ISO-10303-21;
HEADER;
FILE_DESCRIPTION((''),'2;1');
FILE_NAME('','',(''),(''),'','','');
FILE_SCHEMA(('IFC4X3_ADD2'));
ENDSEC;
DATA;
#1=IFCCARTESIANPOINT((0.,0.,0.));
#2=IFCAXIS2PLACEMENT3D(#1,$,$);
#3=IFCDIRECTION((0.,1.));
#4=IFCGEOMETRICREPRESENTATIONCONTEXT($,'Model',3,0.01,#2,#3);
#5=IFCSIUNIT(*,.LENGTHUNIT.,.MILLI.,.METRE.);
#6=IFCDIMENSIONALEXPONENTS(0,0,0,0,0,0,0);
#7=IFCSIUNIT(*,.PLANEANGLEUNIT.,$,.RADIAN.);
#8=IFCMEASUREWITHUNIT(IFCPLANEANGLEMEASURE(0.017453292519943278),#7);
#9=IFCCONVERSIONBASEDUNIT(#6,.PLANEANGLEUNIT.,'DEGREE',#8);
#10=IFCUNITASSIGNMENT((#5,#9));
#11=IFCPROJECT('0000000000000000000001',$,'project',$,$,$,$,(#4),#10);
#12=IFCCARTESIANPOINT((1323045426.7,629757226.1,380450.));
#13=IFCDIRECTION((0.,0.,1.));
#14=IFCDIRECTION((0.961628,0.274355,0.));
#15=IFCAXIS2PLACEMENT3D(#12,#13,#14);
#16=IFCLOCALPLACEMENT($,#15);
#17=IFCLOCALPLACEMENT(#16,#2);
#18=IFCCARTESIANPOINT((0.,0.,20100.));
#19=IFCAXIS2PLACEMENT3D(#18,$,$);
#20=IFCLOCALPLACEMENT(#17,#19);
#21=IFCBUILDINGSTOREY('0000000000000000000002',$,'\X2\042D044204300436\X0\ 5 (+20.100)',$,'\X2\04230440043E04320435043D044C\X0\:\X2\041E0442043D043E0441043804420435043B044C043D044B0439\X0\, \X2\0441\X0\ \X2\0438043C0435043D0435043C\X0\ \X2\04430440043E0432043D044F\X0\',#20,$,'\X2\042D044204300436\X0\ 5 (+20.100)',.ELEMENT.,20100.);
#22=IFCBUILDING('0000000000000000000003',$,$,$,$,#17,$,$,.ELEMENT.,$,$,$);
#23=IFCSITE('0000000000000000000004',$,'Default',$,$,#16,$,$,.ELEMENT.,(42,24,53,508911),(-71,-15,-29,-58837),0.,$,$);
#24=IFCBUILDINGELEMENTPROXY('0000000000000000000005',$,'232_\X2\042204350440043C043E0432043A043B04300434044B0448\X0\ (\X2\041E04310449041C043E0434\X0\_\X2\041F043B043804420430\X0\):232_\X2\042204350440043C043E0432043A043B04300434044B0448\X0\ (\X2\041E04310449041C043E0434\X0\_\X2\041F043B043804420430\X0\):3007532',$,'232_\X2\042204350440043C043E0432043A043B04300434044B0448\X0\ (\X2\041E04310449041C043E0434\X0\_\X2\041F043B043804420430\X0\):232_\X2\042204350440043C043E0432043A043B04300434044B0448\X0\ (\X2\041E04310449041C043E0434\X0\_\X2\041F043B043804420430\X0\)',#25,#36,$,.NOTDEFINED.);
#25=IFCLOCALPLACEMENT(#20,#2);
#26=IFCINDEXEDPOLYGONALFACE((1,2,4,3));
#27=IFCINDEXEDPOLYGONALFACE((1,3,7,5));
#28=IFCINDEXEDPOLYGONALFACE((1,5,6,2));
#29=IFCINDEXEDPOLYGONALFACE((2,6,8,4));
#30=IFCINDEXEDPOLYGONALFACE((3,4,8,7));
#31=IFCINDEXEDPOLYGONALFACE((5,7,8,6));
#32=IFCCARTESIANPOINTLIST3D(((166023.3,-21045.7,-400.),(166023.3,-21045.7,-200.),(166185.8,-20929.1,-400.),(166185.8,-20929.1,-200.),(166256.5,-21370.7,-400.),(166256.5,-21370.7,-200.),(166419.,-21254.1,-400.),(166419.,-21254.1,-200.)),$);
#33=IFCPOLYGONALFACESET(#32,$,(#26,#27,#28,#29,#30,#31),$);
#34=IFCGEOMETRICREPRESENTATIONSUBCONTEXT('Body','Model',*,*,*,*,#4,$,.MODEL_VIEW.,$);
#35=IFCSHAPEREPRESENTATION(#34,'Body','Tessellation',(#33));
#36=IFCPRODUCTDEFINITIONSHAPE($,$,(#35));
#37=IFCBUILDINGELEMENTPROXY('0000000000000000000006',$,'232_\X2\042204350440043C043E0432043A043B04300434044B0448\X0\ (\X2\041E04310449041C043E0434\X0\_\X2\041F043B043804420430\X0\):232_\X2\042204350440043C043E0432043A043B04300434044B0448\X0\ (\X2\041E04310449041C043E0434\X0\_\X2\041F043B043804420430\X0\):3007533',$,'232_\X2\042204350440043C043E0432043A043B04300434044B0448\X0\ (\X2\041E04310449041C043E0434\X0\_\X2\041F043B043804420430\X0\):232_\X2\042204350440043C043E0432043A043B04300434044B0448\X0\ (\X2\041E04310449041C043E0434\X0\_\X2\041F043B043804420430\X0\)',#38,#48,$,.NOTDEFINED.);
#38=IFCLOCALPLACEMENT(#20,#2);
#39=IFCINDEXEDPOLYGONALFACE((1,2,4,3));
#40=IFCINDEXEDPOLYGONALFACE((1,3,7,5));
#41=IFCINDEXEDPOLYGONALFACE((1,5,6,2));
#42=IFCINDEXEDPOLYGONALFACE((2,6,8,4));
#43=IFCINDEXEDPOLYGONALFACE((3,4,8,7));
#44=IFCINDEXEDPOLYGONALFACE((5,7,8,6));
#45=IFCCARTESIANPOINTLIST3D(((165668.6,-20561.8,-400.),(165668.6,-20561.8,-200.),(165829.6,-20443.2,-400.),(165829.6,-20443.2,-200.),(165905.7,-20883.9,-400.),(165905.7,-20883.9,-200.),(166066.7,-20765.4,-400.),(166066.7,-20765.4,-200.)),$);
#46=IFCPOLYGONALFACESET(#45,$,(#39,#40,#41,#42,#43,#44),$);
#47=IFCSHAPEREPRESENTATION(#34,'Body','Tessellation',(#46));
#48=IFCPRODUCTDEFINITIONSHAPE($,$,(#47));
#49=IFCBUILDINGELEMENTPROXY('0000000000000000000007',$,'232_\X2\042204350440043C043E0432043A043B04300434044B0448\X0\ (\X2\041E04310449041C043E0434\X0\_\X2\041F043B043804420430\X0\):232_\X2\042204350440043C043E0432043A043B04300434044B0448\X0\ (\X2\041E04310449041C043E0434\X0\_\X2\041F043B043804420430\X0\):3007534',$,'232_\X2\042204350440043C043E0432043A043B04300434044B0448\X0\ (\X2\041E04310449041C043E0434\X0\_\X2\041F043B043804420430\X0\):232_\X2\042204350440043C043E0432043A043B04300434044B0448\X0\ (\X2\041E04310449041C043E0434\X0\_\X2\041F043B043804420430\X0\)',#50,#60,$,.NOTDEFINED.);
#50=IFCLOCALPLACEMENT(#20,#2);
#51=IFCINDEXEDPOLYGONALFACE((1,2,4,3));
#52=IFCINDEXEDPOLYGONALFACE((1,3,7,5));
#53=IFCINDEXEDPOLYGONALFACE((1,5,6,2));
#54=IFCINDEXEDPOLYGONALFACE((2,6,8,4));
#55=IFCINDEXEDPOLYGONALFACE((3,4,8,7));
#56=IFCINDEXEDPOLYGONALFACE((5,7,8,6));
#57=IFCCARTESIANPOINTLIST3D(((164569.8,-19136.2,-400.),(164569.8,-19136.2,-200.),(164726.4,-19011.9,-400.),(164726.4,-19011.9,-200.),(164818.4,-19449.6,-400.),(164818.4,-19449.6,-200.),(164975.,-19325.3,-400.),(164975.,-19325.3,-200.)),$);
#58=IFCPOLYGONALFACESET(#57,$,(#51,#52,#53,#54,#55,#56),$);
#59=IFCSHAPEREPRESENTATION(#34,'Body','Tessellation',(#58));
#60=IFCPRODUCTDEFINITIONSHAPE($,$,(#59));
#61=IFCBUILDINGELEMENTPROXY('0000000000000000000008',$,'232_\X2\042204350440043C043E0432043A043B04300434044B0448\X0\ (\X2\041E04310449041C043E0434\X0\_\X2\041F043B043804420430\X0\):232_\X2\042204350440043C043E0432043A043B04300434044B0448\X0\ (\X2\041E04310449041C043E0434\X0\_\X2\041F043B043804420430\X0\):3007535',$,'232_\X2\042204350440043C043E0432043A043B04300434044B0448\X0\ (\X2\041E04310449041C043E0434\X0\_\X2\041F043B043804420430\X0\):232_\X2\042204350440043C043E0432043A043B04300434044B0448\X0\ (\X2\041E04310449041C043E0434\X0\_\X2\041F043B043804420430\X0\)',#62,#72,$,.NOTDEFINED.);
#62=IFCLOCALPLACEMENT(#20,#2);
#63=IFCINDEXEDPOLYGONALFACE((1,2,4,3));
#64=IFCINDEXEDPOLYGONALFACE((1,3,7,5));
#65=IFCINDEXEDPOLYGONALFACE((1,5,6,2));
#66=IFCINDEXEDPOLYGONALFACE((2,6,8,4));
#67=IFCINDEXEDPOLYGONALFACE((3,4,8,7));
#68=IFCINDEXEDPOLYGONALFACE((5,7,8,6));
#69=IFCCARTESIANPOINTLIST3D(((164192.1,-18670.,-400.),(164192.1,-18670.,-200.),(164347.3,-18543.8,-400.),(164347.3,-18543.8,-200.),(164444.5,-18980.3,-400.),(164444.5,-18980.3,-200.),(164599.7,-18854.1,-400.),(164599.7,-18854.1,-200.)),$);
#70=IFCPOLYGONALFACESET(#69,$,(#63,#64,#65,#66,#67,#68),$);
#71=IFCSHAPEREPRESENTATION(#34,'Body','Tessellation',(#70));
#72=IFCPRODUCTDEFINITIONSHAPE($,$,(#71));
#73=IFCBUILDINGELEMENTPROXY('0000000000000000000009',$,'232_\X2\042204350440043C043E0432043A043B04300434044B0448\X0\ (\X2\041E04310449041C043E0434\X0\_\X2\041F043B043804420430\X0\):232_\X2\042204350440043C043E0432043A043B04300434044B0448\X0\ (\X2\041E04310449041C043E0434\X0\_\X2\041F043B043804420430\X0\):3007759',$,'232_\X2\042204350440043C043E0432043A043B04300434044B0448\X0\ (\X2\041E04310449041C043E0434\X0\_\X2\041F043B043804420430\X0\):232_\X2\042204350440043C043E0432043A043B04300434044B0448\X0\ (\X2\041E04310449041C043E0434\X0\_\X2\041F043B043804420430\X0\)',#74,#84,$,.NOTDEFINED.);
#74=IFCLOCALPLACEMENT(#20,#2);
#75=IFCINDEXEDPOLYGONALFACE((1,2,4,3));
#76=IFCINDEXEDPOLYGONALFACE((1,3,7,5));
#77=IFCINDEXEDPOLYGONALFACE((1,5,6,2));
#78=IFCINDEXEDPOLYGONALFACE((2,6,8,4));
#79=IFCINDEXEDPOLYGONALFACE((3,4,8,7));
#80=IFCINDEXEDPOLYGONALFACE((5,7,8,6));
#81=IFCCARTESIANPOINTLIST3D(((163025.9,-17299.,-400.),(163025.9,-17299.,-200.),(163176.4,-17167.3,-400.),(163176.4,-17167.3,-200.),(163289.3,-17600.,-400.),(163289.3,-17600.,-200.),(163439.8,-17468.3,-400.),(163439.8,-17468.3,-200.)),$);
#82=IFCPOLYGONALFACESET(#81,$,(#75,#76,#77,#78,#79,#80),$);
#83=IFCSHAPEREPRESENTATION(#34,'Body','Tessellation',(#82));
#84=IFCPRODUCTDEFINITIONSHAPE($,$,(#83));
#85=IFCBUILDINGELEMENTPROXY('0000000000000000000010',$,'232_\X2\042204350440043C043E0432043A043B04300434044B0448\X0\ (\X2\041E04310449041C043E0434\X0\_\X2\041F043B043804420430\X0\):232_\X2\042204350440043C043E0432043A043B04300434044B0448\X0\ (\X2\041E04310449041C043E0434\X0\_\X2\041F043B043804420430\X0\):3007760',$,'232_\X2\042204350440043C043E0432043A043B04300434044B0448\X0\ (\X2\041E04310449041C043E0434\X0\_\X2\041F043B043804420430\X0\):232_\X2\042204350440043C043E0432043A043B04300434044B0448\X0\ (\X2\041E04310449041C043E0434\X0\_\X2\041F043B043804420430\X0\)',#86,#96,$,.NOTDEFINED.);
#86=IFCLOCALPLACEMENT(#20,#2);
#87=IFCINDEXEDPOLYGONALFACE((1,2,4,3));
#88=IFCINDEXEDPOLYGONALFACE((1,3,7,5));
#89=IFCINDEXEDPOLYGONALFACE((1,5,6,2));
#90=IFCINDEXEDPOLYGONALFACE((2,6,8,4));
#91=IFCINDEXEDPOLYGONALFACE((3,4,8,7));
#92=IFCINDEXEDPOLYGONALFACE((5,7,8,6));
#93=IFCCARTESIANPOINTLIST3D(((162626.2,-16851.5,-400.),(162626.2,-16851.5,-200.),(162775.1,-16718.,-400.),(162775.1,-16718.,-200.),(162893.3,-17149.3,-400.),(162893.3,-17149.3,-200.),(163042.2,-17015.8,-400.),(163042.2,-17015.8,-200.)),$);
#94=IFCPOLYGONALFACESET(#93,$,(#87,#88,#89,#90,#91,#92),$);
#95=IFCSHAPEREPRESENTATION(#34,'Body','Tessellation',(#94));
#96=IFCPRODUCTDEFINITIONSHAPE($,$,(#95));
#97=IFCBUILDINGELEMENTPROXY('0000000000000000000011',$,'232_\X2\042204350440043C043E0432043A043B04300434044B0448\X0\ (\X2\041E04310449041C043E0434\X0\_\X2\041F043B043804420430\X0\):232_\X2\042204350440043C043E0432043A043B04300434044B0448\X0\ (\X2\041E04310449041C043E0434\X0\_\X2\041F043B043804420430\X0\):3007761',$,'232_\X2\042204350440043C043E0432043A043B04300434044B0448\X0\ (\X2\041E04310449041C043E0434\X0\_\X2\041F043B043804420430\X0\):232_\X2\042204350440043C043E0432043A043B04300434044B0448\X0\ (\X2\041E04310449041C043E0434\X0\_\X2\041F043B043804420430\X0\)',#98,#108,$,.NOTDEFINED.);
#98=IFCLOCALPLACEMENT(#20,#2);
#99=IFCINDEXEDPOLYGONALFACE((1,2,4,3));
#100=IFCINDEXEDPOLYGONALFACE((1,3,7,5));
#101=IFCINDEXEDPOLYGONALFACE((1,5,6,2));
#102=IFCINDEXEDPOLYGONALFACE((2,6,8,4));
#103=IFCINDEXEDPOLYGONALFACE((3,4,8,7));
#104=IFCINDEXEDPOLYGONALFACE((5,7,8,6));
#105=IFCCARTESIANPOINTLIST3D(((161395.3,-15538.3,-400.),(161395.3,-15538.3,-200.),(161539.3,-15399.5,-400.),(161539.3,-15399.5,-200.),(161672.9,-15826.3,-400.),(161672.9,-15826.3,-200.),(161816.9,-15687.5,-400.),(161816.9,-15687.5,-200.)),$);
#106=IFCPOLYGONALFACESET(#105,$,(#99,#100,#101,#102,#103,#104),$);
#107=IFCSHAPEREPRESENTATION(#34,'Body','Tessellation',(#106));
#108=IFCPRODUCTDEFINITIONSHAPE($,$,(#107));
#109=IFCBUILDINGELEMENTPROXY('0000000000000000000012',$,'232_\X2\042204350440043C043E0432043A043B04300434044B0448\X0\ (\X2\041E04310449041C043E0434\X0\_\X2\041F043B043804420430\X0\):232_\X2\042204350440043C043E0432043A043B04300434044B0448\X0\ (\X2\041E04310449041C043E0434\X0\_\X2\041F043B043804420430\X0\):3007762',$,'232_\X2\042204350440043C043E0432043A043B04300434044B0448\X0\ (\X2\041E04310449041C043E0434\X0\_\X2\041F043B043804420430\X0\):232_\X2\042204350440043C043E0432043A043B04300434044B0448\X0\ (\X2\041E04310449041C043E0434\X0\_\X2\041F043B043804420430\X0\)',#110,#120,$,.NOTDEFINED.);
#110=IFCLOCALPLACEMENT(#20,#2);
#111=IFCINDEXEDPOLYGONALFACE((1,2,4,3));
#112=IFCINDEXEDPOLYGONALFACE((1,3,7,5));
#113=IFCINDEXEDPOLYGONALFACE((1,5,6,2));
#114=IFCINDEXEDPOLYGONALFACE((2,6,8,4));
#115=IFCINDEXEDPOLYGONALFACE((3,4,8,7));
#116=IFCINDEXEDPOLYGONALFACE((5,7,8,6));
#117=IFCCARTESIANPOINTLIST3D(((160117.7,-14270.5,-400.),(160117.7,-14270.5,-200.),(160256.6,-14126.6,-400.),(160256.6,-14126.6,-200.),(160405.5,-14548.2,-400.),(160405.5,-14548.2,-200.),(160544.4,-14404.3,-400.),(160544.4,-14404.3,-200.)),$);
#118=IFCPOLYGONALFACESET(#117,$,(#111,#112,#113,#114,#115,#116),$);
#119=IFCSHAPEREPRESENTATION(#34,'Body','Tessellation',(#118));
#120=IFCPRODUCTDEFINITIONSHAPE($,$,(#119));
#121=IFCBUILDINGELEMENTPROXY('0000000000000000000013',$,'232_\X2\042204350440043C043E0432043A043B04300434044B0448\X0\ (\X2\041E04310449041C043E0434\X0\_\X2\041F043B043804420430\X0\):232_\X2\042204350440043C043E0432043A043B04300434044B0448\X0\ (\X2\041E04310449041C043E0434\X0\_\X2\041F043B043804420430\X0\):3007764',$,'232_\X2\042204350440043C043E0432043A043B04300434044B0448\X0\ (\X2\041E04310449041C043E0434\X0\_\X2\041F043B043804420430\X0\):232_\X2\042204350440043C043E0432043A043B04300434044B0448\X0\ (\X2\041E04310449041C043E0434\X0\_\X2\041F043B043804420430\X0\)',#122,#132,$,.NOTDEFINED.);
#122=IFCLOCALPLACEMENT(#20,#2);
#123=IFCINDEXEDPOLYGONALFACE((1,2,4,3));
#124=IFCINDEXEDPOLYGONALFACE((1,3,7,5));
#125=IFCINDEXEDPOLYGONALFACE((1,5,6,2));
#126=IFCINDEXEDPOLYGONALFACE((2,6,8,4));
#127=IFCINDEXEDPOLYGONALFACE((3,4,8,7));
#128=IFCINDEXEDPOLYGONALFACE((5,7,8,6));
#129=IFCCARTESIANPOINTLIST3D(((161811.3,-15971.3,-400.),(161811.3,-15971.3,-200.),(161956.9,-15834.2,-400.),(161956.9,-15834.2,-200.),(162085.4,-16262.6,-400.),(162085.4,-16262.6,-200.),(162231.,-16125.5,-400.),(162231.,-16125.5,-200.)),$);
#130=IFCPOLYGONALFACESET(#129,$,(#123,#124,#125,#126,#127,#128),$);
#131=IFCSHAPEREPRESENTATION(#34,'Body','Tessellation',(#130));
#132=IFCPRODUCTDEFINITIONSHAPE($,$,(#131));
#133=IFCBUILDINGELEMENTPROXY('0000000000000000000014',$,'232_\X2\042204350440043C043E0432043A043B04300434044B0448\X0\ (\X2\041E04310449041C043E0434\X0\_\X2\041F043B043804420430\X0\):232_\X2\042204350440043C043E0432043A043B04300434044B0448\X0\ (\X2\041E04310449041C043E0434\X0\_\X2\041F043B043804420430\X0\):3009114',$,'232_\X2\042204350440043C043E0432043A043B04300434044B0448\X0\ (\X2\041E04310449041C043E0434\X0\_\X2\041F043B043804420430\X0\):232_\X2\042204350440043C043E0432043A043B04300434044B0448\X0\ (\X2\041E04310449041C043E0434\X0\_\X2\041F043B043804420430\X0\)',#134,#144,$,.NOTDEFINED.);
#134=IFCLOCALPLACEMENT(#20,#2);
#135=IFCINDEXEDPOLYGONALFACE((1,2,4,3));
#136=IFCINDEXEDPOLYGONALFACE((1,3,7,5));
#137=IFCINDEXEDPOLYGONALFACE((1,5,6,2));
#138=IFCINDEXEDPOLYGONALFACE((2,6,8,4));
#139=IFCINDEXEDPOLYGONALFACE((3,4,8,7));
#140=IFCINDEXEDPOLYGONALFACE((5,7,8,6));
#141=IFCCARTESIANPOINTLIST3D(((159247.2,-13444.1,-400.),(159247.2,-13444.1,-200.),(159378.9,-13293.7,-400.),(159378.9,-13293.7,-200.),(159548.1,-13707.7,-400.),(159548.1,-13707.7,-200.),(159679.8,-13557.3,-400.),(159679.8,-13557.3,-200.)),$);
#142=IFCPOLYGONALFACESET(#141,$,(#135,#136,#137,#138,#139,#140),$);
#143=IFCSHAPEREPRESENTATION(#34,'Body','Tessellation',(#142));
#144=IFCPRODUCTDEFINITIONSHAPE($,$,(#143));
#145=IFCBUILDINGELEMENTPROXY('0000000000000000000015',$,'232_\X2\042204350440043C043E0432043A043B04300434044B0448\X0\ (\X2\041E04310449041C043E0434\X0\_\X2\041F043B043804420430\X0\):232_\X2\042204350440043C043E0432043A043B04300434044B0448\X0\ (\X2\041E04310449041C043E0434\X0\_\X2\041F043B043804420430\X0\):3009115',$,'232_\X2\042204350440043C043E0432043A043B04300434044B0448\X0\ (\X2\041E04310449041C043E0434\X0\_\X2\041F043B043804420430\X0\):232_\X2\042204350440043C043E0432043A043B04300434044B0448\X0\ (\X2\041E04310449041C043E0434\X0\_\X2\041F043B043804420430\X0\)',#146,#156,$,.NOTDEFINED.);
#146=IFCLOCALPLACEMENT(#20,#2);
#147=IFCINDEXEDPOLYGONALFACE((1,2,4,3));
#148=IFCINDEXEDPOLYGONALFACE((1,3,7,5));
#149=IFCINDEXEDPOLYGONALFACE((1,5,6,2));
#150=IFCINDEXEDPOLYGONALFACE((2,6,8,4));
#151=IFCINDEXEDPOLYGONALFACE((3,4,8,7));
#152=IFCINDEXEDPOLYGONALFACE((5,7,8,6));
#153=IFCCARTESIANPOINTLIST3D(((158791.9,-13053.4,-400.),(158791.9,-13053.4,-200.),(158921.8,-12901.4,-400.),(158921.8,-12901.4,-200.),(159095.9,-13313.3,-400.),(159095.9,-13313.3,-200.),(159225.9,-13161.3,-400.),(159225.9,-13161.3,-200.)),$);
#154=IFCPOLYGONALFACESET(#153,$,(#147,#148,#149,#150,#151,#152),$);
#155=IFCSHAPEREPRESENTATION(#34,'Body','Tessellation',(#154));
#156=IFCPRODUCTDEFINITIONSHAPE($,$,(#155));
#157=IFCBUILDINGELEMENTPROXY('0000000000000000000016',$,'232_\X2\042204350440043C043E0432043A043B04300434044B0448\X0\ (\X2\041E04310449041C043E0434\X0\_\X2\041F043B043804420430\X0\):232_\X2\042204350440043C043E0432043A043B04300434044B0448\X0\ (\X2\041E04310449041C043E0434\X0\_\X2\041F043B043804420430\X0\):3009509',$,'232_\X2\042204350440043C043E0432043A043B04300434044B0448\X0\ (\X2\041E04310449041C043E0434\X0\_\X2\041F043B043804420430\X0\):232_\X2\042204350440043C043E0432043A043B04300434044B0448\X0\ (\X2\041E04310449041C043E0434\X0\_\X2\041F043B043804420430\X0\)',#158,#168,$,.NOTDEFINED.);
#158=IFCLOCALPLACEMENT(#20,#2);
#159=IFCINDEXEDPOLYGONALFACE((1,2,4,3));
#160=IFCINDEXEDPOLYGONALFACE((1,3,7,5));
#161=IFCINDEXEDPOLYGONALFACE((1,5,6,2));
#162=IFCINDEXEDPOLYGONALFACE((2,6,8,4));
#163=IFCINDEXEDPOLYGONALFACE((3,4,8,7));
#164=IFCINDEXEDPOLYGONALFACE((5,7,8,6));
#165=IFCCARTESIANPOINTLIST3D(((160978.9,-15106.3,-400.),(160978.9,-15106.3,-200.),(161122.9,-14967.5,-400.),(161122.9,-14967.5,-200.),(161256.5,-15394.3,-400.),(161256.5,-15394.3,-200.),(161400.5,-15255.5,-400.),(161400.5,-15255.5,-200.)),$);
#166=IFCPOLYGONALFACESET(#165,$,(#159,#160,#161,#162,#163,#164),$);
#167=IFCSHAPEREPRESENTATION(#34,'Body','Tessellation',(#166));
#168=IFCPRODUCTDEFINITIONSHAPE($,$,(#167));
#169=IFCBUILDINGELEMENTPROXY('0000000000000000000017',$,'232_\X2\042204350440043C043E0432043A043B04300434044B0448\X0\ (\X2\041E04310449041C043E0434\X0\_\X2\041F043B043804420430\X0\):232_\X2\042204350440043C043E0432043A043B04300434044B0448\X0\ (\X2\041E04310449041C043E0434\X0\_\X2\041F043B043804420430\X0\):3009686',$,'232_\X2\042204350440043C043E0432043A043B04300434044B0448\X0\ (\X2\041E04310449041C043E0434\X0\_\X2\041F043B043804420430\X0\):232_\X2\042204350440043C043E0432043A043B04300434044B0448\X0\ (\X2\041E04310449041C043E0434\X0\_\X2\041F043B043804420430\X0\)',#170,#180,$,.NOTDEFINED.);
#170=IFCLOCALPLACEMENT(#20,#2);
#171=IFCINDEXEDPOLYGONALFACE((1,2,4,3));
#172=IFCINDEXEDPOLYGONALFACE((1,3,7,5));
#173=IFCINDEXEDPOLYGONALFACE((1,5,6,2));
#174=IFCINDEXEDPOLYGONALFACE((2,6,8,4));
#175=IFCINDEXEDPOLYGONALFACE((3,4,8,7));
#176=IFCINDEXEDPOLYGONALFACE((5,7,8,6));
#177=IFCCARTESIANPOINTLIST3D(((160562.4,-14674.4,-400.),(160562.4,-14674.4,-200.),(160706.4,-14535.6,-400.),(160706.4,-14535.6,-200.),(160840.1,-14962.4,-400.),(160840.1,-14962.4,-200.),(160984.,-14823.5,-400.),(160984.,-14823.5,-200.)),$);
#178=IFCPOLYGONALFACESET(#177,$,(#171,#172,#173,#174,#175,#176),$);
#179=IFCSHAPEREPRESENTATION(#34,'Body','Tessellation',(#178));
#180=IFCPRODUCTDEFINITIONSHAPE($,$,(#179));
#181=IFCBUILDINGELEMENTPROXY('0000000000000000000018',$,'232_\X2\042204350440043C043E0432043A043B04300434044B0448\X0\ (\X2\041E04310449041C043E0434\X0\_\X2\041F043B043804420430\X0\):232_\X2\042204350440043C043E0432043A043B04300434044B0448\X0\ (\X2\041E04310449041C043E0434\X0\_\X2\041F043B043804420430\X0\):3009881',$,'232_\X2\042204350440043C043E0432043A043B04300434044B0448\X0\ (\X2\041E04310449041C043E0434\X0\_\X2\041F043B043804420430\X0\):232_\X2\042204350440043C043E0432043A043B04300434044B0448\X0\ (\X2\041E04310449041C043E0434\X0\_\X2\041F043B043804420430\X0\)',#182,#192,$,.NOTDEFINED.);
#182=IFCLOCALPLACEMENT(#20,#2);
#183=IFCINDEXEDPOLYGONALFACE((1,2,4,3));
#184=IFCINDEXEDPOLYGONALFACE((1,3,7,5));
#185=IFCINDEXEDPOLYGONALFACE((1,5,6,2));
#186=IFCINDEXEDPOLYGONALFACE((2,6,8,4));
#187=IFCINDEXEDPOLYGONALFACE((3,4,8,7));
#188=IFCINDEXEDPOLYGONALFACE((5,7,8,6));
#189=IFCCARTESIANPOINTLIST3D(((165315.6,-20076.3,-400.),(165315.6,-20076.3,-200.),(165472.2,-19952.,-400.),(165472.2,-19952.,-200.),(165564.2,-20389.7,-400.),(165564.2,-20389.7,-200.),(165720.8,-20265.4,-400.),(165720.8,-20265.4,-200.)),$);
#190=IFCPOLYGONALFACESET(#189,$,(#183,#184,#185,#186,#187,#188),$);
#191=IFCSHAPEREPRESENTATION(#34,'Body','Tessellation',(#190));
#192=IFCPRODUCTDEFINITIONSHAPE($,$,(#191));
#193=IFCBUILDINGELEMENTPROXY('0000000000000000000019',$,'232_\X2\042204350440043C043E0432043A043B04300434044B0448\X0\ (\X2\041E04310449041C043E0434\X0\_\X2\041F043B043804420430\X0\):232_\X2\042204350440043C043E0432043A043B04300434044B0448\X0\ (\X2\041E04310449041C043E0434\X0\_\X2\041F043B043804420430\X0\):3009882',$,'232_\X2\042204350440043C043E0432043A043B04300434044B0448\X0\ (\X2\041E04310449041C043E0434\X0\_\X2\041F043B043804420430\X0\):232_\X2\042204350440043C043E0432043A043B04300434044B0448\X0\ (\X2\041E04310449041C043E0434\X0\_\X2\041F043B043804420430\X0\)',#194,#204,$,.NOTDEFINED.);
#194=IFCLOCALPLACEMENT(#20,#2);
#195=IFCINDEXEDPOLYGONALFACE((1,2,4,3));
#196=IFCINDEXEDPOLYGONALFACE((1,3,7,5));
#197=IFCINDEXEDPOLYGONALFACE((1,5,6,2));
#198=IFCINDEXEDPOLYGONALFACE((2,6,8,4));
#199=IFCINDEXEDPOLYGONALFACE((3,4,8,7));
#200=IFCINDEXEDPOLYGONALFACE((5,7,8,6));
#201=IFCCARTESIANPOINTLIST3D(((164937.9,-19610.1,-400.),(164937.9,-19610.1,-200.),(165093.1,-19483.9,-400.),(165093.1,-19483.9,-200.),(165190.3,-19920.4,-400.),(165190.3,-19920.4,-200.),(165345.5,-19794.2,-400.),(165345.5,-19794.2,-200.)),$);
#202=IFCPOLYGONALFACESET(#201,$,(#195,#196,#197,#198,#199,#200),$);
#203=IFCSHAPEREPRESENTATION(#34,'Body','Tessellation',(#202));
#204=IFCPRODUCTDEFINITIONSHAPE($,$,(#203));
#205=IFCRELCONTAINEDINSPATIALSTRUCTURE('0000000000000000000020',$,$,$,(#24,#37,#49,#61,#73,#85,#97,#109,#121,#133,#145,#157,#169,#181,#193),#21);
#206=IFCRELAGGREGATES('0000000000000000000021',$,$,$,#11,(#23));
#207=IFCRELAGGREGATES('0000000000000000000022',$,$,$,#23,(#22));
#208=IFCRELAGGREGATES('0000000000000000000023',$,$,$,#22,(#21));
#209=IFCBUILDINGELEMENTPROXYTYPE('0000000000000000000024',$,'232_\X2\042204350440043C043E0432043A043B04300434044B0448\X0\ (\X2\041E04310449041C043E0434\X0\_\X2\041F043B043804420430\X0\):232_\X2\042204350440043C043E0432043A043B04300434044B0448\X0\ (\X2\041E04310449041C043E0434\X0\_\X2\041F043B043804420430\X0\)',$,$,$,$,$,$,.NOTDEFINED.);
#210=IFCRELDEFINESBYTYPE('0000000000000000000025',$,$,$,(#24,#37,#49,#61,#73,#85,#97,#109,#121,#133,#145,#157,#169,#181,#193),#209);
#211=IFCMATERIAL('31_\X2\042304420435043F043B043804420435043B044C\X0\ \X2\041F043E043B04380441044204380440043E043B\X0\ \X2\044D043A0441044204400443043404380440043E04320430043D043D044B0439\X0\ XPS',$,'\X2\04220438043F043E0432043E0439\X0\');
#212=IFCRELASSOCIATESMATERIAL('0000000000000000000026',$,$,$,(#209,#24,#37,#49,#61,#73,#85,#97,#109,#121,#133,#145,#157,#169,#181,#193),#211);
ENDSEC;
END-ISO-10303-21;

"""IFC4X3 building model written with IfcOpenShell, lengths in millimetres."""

from ifc_helpers import new_model, entity, si_unit, converted_unit, direction, frame, origin, origin_2d_with_axis, place, context, subcontext, project, spatial, rectangle, extrude, source, transform, mapped, material, type_object, type_shapes, element, save


model = new_model("IFC4X3")

# Units and contexts
model_context = context("Model", 3, precision=0.01, world=origin(), true_north=direction((0.0, 1.0)))
body_context = subcontext(model_context, "Body", "Model", "MODEL_VIEW")
ifc_project = project(units=[si_unit("LENGTHUNIT", "METRE", prefix="MILLI"), converted_unit("PLANEANGLEUNIT", "DEGREE", entity("IfcPlaneAngleMeasure", 0.017453292519943278), si_unit("PLANEANGLEUNIT", "RADIAN"), dimensions=[0, 0, 0, 0, 0, 0, 0])], contexts=[model_context])

# Site, building, storey
site_placement = place(None, frame((1323045426.7, 629757226.1, 380450.0), z_axis=(0.0, 0.0, 1.0), x_axis=(0.961628, 0.274355, 0.0)))
site = spatial("IfcSite", under=ifc_project, at=site_placement, Name="Default", CompositionType="ELEMENT", RefLatitude=(42, 24, 53, 508911), RefLongitude=(-71, -15, -29, -58837), RefElevation=0.0)
building_placement = place(site_placement, origin())
building = spatial("IfcBuilding", under=site, at=building_placement, CompositionType="ELEMENT")
storey_placement = place(building_placement, frame((0.0, 0.0, 20100.0)))
storey = spatial("IfcBuildingStorey", under=building, at=storey_placement, Name="Этаж 5 (+20.100)", ObjectType="Уровень:Относительный, с именем уровня", LongName="Этаж 5 (+20.100)", CompositionType="ELEMENT", Elevation=20100.0)

# Building element proxies
ifc_material = material(Name="31_Утеплитель Полистирол экструдированный XPS", Category="Типовой")
building_element_proxy_type_1 = type_object("IfcBuildingElementProxyType", Name="232_Термовкладыш (ОбщМод_Плита):232_Термовкладыш (ОбщМод_Плита)", PredefinedType="NOTDEFINED", material=ifc_material)
shared_shape_1 = source(origin(), body_context, "Body", "SweptSolid", [
    extrude(rectangle(XDim=400.0, YDim=200.0, at=origin_2d_with_axis()), frame((200.0, 0.0, -200.0), z_axis=(0.0, 0.0, 1.0), x_axis=(-1.0, 0.0, 0.0)), (0.0, 0.0, 1.0), 200.0),
])
type_shapes(building_element_proxy_type_1, [shared_shape_1])
for number, where, z_axis, x_axis, name in (
    (1, (166104.5, -20987.4, -200.0), (0.0, 0.0, 1.0), (0.583023, -0.812456, 0.0), "232_Термовкладыш (ОбщМод_Плита):232_Термовкладыш (ОбщМод_Плита):3007532"),
    (2, (165749.1, -20502.5, -200.0), (0.0, 0.0, 1.0), (0.592773, -0.80537, 0.0), "232_Термовкладыш (ОбщМод_Плита):232_Термовкладыш (ОбщМод_Плита):3007533"),
    (3, (164648.1, -19074.1, -200.0), (0.0, 0.0, 1.0), (0.621501, -0.783414, 0.0), "232_Термовкладыш (ОбщМод_Плита):232_Термовкладыш (ОбщМод_Плита):3007534"),
    (4, (164269.7, -18606.9, -200.0), (0.0, 0.0, 1.0), (0.630898, -0.775866, 0.0), "232_Термовкладыш (ОбщМод_Плита):232_Термовкладыш (ОбщМод_Плита):3007535"),
    (5, (163101.2, -17233.1, -200.0), (0.0, 0.0, 1.0), (0.658534, -0.752551, 0.0), "232_Термовкладыш (ОбщМод_Плита):232_Термовкладыш (ОбщМод_Плита):3007759"),
    (6, (162700.7, -16784.7, -200.0), (0.0, 0.0, 1.0), (0.667556, -0.744559, 0.0), "232_Термовкладыш (ОбщМод_Плита):232_Термовкладыш (ОбщМод_Плита):3007760"),
    (7, (161467.3, -15468.9, -200.0), (0.0, 0.0, 1.0), (0.694037, -0.71994, 0.0), "232_Термовкладыш (ОбщМод_Плита):232_Термовкладыш (ОбщМод_Плита):3007761"),
    (8, (160187.1, -14198.5, -200.0), (0.0, 0.0, 1.0), (0.71961, -0.694379, 0.0), "232_Термовкладыш (ОбщМод_Плита):232_Термовкладыш (ОбщМод_Плита):3007762"),
    (9, (161884.1, -15902.8, -200.0), (0.0, 0.0, 1.0), (0.685309, -0.728252, 0.0), "232_Термовкладыш (ОбщМод_Плита):232_Термовкладыш (ОбщМод_Плита):3007764"),
    (10, (159313.1, -13368.9, -200.0), (0.0, 0.0, 1.0), (0.752238, -0.658891, 0.0), "232_Термовкладыш (ОбщМод_Плита):232_Термовкладыш (ОбщМод_Плита):3009114"),
    (11, (158856.8, -12977.4, -200.0), (0.0, 0.0, 1.0), (0.760125, -0.649777, 0.0), "232_Термовкладыш (ОбщМод_Плита):232_Термовкладыш (ОбщМод_Плита):3009115"),
    (12, (161050.9, -15036.9, -200.0), (0.0, 0.0, 1.0), (0.694037, -0.71994, 0.0), "232_Термовкладыш (ОбщМод_Плита):232_Термовкладыш (ОбщМод_Плита):3009509"),
    (13, (160634.4, -14605.0, -200.0), (0.0, 0.0, 1.0), (0.694037, -0.71994, 0.0), "232_Термовкладыш (ОбщМод_Плита):232_Термовкладыш (ОбщМод_Плита):3009686"),
    (14, (165393.9, -20014.2, -200.0), (0.0, 0.0, 1.0), (0.621501, -0.783414, 0.0), "232_Термовкладыш (ОбщМод_Плита):232_Термовкладыш (ОбщМод_Плита):3009881"),
    (15, (165015.5, -19547.0, -200.0), (0.0, 0.0, 1.0), (0.630898, -0.775866, 0.0), "232_Термовкладыш (ОбщМод_Плита):232_Термовкладыш (ОбщМод_Плита):3009882"),
):
    element("IfcBuildingElementProxy", number, at=place(storey_placement, frame(where, z_axis=z_axis, x_axis=x_axis)), inside=storey, type_object=building_element_proxy_type_1, material=ifc_material, Name=name, ObjectType="232_Термовкладыш (ОбщМод_Плита):232_Термовкладыш (ОбщМод_Плита)", PredefinedType="NOTDEFINED", context=body_context, shape_type="MappedRepresentation", body=[
        mapped(shared_shape_1, transform((0.0, 0.0, 0.0), scale=1.0)),
    ])

save(model, "model.ifc")
